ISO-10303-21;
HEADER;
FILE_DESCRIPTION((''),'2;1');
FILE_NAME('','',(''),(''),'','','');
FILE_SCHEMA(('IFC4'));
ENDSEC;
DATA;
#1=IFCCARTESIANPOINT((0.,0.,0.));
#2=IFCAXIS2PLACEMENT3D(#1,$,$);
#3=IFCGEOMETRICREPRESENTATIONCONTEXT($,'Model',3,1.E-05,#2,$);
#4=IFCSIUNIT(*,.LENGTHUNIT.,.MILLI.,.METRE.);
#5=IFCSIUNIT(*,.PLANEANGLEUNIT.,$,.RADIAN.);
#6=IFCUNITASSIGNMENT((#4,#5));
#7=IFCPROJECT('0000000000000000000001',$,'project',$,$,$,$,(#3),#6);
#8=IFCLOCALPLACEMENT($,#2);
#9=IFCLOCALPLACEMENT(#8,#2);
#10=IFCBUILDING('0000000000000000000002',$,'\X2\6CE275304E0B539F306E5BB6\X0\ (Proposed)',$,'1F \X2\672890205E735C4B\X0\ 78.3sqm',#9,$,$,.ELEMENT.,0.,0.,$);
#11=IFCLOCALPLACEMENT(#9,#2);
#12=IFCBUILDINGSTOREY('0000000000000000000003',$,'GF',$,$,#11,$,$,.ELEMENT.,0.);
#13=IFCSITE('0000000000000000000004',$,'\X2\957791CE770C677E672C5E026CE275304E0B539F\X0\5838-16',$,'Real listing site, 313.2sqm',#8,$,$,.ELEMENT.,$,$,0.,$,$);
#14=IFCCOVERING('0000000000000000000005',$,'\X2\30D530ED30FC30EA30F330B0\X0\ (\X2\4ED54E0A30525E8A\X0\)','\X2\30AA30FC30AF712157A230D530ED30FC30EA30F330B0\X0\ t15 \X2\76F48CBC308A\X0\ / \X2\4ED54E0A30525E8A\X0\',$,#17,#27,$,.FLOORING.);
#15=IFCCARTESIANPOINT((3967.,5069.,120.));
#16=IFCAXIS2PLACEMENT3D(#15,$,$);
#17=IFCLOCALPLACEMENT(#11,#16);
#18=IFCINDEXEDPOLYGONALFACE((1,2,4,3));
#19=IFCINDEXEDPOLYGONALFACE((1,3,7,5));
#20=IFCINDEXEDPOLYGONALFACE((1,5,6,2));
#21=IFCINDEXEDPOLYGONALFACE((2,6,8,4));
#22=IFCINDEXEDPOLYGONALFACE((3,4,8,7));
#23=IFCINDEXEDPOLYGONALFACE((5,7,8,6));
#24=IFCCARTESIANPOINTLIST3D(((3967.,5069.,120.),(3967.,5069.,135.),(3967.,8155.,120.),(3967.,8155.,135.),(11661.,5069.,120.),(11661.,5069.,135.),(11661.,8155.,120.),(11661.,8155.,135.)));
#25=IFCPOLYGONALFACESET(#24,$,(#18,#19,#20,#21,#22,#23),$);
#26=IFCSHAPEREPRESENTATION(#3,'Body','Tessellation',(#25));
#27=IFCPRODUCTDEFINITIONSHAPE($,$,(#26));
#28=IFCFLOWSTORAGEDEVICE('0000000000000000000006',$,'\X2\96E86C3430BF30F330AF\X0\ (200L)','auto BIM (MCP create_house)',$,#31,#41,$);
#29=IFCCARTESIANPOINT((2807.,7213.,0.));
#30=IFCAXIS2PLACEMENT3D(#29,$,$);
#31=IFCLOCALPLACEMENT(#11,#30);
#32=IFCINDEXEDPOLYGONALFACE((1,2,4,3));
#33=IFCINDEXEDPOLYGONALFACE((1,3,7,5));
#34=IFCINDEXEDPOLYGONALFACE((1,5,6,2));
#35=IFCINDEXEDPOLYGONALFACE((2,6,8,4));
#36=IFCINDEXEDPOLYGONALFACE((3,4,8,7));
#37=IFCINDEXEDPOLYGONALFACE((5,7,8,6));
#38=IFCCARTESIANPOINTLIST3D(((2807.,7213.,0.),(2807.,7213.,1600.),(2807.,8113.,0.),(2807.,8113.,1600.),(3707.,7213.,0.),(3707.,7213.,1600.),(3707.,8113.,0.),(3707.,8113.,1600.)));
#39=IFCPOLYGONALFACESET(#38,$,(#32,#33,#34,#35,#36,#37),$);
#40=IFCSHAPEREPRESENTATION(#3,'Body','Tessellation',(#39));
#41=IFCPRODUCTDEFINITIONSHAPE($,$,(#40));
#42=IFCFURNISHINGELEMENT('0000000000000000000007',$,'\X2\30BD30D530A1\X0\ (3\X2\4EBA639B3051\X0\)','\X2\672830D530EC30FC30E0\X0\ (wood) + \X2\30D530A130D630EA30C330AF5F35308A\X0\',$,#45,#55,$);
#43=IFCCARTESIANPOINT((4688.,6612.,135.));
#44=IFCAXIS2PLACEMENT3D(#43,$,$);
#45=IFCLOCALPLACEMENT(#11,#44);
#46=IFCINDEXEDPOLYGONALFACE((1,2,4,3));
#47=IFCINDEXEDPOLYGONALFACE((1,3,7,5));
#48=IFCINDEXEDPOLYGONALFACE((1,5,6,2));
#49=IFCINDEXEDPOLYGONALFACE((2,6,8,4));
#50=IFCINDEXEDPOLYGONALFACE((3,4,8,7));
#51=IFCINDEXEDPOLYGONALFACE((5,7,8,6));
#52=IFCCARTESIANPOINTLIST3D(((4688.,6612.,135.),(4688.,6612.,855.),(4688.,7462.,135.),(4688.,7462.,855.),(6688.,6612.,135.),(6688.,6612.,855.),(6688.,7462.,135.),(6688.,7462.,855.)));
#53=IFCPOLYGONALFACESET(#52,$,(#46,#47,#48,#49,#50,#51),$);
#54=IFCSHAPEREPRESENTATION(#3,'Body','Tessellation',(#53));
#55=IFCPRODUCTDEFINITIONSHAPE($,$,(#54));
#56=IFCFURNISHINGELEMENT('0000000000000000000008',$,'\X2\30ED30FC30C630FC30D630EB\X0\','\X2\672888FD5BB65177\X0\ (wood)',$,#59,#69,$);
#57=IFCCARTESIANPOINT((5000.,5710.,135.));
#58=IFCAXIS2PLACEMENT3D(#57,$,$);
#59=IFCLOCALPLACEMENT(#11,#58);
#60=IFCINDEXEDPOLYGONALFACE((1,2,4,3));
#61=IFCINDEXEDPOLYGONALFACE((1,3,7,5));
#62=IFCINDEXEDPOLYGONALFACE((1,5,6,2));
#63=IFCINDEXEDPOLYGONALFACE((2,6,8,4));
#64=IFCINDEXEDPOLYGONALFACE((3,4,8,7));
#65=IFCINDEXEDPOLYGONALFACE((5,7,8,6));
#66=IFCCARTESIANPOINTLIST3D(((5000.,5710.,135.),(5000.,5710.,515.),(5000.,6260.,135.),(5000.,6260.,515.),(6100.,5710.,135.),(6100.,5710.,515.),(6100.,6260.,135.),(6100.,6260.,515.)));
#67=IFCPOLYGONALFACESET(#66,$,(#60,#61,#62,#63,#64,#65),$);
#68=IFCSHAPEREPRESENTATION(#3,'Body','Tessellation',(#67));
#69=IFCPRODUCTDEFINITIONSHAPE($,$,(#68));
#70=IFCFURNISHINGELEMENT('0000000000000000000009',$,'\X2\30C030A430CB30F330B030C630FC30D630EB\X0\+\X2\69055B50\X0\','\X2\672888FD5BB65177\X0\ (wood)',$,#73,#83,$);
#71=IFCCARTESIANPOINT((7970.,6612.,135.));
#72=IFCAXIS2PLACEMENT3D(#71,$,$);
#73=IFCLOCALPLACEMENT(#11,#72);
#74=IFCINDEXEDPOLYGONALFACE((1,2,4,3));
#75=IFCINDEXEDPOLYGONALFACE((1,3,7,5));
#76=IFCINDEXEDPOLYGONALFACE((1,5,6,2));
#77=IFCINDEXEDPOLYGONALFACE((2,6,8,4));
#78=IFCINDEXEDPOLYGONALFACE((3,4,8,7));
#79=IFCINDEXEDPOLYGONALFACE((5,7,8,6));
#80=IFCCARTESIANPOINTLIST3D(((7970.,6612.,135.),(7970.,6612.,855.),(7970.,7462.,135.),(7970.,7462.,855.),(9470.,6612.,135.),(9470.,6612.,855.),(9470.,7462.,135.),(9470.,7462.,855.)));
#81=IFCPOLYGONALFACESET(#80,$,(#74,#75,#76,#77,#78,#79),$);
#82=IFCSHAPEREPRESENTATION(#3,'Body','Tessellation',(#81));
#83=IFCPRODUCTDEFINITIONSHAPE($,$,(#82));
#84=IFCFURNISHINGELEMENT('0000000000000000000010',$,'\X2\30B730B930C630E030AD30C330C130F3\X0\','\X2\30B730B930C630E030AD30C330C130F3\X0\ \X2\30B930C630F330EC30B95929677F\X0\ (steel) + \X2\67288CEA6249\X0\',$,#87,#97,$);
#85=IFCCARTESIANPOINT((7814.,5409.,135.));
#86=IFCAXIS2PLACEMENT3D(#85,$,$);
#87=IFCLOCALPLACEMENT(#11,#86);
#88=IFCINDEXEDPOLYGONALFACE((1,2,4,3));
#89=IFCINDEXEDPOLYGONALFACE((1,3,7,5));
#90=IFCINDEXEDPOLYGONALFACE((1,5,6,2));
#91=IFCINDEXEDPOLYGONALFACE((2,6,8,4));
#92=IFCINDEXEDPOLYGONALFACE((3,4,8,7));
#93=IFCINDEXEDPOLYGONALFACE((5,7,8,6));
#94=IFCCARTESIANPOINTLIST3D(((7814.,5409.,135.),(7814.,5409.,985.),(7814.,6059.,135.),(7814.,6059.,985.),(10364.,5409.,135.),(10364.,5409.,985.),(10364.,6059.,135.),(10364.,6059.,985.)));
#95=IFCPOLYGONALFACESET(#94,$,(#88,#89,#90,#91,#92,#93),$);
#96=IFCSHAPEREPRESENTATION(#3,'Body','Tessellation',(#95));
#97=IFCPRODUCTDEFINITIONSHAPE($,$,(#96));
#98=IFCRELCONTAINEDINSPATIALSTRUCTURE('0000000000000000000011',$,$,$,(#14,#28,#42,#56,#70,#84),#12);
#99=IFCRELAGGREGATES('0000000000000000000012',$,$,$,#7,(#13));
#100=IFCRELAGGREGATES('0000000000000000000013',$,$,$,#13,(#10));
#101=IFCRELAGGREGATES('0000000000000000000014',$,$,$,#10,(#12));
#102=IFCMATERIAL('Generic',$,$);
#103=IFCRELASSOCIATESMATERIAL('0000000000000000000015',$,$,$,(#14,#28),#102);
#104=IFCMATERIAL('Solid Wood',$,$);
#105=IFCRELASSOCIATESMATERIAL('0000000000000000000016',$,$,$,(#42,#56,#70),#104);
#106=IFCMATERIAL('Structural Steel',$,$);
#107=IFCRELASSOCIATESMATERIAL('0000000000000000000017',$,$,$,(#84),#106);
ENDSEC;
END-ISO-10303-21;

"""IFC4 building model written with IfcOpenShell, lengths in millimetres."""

from ifc_helpers import new_model, si_unit, frame, frame_2d, origin, place, context, project, spatial, rectangle, extrude, material, element, save


model = new_model("IFC4")

# Units and contexts
model_context = context("Model", 3, precision=1e-05, world=origin())
ifc_project = project(units=[si_unit("LENGTHUNIT", "METRE", prefix="MILLI"), si_unit("PLANEANGLEUNIT", "RADIAN")], contexts=[model_context])

# Site, building, storey
site_placement = place(None, origin())
site = spatial("IfcSite", under=ifc_project, at=site_placement, Name="長野県松本市波田下原5838-16", ObjectType="Real listing site, 313.2sqm", CompositionType="ELEMENT", RefElevation=0.0)
building_placement = place(site_placement, origin())
building = spatial("IfcBuilding", under=site, at=building_placement, Name="波田下原の家 (Proposed)", ObjectType="1F 木造平屋 78.3sqm", CompositionType="ELEMENT", ElevationOfRefHeight=0.0, ElevationOfTerrain=0.0)
storey_placement = place(building_placement, origin())
storey = spatial("IfcBuildingStorey", under=building, at=storey_placement, Name="GF", CompositionType="ELEMENT", Elevation=0.0)

# Shared definitions
ifc_material_1 = material(Name="Solid Wood")

# Shared definitions
ifc_material_2 = material(Name="Structural Steel")

# Covering
ifc_material_3 = material(Name="Generic")
covering_placement = place(storey_placement, frame((3967.0, 5069.0, 120.0)))
element("IfcCovering", 1, at=covering_placement, inside=storey, material=ifc_material_3, Name="フローリング (仕上げ床)", Description="オーク無垢フローリング t15 直貼り / 仕上げ床", PredefinedType="FLOORING", context=model_context, shape_type="SweptSolid", body=[
    extrude(rectangle(XDim=7694.0, YDim=3086.0, at=frame_2d((3847.0, 1543.0))), frame((3967.0, 5069.0, 120.0)), (0.0, 0.0, 1.0), 15.0),
])

# Flow storage device
flow_storage_device_placement = place(storey_placement, frame((2807.0, 7213.0, 0.0)))
element("IfcFlowStorageDevice", 2, at=flow_storage_device_placement, inside=storey, material=ifc_material_3, Name="雨水タンク (200L)", Description="auto BIM (MCP create_house)", context=model_context, shape_type="SweptSolid", body=[
    extrude(rectangle(XDim=900.0, YDim=900.0, at=frame_2d((450.0, 450.0))), frame((2807.0, 7213.0, 0.0)), (0.0, 0.0, 1.0), 1600.0),
])

# Furnishing elements
furnishing_1_placement = place(storey_placement, frame((4688.0, 6612.0, 135.0)))
element("IfcFurnishingElement", 3, at=furnishing_1_placement, inside=storey, material=ifc_material_1, Name="ソファ (3人掛け)", Description="木フレーム (wood) + ファブリック張り", context=model_context, shape_type="SweptSolid", body=[
    extrude(rectangle(XDim=2000.0, YDim=850.0, at=frame_2d((1000.0, 425.0))), frame((4688.0, 6612.0, 135.0)), (0.0, 0.0, 1.0), 720.0),
])
furnishing_2_placement = place(storey_placement, frame((5000.0, 5710.0, 135.0)))
element("IfcFurnishingElement", 4, at=furnishing_2_placement, inside=storey, material=ifc_material_1, Name="ローテーブル", Description="木製家具 (wood)", context=model_context, shape_type="SweptSolid", body=[
    extrude(rectangle(XDim=1100.0, YDim=550.0, at=frame_2d((550.0, 275.0))), frame((5000.0, 5710.0, 135.0)), (0.0, 0.0, 1.0), 380.0),
])
furnishing_3_placement = place(storey_placement, frame((7970.0, 6612.0, 135.0)))
element("IfcFurnishingElement", 5, at=furnishing_3_placement, inside=storey, material=ifc_material_1, Name="ダイニングテーブル+椅子", Description="木製家具 (wood)", context=model_context, shape_type="SweptSolid", body=[
    extrude(rectangle(XDim=1500.0, YDim=850.0, at=frame_2d((750.0, 425.0))), frame((7970.0, 6612.0, 135.0)), (0.0, 0.0, 1.0), 720.0),
])
furnishing_4_placement = place(storey_placement, frame((7814.0, 5409.0, 135.0)))
element("IfcFurnishingElement", 6, at=furnishing_4_placement, inside=storey, material=ifc_material_2, Name="システムキッチン", Description="システムキッチン ステンレス天板 (steel) + 木質扉", context=model_context, shape_type="SweptSolid", body=[
    extrude(rectangle(XDim=2550.0, YDim=650.0, at=frame_2d((1275.0, 325.0))), frame((7814.0, 5409.0, 135.0)), (0.0, 0.0, 1.0), 850.0),
])

save(model, "model.ifc")
